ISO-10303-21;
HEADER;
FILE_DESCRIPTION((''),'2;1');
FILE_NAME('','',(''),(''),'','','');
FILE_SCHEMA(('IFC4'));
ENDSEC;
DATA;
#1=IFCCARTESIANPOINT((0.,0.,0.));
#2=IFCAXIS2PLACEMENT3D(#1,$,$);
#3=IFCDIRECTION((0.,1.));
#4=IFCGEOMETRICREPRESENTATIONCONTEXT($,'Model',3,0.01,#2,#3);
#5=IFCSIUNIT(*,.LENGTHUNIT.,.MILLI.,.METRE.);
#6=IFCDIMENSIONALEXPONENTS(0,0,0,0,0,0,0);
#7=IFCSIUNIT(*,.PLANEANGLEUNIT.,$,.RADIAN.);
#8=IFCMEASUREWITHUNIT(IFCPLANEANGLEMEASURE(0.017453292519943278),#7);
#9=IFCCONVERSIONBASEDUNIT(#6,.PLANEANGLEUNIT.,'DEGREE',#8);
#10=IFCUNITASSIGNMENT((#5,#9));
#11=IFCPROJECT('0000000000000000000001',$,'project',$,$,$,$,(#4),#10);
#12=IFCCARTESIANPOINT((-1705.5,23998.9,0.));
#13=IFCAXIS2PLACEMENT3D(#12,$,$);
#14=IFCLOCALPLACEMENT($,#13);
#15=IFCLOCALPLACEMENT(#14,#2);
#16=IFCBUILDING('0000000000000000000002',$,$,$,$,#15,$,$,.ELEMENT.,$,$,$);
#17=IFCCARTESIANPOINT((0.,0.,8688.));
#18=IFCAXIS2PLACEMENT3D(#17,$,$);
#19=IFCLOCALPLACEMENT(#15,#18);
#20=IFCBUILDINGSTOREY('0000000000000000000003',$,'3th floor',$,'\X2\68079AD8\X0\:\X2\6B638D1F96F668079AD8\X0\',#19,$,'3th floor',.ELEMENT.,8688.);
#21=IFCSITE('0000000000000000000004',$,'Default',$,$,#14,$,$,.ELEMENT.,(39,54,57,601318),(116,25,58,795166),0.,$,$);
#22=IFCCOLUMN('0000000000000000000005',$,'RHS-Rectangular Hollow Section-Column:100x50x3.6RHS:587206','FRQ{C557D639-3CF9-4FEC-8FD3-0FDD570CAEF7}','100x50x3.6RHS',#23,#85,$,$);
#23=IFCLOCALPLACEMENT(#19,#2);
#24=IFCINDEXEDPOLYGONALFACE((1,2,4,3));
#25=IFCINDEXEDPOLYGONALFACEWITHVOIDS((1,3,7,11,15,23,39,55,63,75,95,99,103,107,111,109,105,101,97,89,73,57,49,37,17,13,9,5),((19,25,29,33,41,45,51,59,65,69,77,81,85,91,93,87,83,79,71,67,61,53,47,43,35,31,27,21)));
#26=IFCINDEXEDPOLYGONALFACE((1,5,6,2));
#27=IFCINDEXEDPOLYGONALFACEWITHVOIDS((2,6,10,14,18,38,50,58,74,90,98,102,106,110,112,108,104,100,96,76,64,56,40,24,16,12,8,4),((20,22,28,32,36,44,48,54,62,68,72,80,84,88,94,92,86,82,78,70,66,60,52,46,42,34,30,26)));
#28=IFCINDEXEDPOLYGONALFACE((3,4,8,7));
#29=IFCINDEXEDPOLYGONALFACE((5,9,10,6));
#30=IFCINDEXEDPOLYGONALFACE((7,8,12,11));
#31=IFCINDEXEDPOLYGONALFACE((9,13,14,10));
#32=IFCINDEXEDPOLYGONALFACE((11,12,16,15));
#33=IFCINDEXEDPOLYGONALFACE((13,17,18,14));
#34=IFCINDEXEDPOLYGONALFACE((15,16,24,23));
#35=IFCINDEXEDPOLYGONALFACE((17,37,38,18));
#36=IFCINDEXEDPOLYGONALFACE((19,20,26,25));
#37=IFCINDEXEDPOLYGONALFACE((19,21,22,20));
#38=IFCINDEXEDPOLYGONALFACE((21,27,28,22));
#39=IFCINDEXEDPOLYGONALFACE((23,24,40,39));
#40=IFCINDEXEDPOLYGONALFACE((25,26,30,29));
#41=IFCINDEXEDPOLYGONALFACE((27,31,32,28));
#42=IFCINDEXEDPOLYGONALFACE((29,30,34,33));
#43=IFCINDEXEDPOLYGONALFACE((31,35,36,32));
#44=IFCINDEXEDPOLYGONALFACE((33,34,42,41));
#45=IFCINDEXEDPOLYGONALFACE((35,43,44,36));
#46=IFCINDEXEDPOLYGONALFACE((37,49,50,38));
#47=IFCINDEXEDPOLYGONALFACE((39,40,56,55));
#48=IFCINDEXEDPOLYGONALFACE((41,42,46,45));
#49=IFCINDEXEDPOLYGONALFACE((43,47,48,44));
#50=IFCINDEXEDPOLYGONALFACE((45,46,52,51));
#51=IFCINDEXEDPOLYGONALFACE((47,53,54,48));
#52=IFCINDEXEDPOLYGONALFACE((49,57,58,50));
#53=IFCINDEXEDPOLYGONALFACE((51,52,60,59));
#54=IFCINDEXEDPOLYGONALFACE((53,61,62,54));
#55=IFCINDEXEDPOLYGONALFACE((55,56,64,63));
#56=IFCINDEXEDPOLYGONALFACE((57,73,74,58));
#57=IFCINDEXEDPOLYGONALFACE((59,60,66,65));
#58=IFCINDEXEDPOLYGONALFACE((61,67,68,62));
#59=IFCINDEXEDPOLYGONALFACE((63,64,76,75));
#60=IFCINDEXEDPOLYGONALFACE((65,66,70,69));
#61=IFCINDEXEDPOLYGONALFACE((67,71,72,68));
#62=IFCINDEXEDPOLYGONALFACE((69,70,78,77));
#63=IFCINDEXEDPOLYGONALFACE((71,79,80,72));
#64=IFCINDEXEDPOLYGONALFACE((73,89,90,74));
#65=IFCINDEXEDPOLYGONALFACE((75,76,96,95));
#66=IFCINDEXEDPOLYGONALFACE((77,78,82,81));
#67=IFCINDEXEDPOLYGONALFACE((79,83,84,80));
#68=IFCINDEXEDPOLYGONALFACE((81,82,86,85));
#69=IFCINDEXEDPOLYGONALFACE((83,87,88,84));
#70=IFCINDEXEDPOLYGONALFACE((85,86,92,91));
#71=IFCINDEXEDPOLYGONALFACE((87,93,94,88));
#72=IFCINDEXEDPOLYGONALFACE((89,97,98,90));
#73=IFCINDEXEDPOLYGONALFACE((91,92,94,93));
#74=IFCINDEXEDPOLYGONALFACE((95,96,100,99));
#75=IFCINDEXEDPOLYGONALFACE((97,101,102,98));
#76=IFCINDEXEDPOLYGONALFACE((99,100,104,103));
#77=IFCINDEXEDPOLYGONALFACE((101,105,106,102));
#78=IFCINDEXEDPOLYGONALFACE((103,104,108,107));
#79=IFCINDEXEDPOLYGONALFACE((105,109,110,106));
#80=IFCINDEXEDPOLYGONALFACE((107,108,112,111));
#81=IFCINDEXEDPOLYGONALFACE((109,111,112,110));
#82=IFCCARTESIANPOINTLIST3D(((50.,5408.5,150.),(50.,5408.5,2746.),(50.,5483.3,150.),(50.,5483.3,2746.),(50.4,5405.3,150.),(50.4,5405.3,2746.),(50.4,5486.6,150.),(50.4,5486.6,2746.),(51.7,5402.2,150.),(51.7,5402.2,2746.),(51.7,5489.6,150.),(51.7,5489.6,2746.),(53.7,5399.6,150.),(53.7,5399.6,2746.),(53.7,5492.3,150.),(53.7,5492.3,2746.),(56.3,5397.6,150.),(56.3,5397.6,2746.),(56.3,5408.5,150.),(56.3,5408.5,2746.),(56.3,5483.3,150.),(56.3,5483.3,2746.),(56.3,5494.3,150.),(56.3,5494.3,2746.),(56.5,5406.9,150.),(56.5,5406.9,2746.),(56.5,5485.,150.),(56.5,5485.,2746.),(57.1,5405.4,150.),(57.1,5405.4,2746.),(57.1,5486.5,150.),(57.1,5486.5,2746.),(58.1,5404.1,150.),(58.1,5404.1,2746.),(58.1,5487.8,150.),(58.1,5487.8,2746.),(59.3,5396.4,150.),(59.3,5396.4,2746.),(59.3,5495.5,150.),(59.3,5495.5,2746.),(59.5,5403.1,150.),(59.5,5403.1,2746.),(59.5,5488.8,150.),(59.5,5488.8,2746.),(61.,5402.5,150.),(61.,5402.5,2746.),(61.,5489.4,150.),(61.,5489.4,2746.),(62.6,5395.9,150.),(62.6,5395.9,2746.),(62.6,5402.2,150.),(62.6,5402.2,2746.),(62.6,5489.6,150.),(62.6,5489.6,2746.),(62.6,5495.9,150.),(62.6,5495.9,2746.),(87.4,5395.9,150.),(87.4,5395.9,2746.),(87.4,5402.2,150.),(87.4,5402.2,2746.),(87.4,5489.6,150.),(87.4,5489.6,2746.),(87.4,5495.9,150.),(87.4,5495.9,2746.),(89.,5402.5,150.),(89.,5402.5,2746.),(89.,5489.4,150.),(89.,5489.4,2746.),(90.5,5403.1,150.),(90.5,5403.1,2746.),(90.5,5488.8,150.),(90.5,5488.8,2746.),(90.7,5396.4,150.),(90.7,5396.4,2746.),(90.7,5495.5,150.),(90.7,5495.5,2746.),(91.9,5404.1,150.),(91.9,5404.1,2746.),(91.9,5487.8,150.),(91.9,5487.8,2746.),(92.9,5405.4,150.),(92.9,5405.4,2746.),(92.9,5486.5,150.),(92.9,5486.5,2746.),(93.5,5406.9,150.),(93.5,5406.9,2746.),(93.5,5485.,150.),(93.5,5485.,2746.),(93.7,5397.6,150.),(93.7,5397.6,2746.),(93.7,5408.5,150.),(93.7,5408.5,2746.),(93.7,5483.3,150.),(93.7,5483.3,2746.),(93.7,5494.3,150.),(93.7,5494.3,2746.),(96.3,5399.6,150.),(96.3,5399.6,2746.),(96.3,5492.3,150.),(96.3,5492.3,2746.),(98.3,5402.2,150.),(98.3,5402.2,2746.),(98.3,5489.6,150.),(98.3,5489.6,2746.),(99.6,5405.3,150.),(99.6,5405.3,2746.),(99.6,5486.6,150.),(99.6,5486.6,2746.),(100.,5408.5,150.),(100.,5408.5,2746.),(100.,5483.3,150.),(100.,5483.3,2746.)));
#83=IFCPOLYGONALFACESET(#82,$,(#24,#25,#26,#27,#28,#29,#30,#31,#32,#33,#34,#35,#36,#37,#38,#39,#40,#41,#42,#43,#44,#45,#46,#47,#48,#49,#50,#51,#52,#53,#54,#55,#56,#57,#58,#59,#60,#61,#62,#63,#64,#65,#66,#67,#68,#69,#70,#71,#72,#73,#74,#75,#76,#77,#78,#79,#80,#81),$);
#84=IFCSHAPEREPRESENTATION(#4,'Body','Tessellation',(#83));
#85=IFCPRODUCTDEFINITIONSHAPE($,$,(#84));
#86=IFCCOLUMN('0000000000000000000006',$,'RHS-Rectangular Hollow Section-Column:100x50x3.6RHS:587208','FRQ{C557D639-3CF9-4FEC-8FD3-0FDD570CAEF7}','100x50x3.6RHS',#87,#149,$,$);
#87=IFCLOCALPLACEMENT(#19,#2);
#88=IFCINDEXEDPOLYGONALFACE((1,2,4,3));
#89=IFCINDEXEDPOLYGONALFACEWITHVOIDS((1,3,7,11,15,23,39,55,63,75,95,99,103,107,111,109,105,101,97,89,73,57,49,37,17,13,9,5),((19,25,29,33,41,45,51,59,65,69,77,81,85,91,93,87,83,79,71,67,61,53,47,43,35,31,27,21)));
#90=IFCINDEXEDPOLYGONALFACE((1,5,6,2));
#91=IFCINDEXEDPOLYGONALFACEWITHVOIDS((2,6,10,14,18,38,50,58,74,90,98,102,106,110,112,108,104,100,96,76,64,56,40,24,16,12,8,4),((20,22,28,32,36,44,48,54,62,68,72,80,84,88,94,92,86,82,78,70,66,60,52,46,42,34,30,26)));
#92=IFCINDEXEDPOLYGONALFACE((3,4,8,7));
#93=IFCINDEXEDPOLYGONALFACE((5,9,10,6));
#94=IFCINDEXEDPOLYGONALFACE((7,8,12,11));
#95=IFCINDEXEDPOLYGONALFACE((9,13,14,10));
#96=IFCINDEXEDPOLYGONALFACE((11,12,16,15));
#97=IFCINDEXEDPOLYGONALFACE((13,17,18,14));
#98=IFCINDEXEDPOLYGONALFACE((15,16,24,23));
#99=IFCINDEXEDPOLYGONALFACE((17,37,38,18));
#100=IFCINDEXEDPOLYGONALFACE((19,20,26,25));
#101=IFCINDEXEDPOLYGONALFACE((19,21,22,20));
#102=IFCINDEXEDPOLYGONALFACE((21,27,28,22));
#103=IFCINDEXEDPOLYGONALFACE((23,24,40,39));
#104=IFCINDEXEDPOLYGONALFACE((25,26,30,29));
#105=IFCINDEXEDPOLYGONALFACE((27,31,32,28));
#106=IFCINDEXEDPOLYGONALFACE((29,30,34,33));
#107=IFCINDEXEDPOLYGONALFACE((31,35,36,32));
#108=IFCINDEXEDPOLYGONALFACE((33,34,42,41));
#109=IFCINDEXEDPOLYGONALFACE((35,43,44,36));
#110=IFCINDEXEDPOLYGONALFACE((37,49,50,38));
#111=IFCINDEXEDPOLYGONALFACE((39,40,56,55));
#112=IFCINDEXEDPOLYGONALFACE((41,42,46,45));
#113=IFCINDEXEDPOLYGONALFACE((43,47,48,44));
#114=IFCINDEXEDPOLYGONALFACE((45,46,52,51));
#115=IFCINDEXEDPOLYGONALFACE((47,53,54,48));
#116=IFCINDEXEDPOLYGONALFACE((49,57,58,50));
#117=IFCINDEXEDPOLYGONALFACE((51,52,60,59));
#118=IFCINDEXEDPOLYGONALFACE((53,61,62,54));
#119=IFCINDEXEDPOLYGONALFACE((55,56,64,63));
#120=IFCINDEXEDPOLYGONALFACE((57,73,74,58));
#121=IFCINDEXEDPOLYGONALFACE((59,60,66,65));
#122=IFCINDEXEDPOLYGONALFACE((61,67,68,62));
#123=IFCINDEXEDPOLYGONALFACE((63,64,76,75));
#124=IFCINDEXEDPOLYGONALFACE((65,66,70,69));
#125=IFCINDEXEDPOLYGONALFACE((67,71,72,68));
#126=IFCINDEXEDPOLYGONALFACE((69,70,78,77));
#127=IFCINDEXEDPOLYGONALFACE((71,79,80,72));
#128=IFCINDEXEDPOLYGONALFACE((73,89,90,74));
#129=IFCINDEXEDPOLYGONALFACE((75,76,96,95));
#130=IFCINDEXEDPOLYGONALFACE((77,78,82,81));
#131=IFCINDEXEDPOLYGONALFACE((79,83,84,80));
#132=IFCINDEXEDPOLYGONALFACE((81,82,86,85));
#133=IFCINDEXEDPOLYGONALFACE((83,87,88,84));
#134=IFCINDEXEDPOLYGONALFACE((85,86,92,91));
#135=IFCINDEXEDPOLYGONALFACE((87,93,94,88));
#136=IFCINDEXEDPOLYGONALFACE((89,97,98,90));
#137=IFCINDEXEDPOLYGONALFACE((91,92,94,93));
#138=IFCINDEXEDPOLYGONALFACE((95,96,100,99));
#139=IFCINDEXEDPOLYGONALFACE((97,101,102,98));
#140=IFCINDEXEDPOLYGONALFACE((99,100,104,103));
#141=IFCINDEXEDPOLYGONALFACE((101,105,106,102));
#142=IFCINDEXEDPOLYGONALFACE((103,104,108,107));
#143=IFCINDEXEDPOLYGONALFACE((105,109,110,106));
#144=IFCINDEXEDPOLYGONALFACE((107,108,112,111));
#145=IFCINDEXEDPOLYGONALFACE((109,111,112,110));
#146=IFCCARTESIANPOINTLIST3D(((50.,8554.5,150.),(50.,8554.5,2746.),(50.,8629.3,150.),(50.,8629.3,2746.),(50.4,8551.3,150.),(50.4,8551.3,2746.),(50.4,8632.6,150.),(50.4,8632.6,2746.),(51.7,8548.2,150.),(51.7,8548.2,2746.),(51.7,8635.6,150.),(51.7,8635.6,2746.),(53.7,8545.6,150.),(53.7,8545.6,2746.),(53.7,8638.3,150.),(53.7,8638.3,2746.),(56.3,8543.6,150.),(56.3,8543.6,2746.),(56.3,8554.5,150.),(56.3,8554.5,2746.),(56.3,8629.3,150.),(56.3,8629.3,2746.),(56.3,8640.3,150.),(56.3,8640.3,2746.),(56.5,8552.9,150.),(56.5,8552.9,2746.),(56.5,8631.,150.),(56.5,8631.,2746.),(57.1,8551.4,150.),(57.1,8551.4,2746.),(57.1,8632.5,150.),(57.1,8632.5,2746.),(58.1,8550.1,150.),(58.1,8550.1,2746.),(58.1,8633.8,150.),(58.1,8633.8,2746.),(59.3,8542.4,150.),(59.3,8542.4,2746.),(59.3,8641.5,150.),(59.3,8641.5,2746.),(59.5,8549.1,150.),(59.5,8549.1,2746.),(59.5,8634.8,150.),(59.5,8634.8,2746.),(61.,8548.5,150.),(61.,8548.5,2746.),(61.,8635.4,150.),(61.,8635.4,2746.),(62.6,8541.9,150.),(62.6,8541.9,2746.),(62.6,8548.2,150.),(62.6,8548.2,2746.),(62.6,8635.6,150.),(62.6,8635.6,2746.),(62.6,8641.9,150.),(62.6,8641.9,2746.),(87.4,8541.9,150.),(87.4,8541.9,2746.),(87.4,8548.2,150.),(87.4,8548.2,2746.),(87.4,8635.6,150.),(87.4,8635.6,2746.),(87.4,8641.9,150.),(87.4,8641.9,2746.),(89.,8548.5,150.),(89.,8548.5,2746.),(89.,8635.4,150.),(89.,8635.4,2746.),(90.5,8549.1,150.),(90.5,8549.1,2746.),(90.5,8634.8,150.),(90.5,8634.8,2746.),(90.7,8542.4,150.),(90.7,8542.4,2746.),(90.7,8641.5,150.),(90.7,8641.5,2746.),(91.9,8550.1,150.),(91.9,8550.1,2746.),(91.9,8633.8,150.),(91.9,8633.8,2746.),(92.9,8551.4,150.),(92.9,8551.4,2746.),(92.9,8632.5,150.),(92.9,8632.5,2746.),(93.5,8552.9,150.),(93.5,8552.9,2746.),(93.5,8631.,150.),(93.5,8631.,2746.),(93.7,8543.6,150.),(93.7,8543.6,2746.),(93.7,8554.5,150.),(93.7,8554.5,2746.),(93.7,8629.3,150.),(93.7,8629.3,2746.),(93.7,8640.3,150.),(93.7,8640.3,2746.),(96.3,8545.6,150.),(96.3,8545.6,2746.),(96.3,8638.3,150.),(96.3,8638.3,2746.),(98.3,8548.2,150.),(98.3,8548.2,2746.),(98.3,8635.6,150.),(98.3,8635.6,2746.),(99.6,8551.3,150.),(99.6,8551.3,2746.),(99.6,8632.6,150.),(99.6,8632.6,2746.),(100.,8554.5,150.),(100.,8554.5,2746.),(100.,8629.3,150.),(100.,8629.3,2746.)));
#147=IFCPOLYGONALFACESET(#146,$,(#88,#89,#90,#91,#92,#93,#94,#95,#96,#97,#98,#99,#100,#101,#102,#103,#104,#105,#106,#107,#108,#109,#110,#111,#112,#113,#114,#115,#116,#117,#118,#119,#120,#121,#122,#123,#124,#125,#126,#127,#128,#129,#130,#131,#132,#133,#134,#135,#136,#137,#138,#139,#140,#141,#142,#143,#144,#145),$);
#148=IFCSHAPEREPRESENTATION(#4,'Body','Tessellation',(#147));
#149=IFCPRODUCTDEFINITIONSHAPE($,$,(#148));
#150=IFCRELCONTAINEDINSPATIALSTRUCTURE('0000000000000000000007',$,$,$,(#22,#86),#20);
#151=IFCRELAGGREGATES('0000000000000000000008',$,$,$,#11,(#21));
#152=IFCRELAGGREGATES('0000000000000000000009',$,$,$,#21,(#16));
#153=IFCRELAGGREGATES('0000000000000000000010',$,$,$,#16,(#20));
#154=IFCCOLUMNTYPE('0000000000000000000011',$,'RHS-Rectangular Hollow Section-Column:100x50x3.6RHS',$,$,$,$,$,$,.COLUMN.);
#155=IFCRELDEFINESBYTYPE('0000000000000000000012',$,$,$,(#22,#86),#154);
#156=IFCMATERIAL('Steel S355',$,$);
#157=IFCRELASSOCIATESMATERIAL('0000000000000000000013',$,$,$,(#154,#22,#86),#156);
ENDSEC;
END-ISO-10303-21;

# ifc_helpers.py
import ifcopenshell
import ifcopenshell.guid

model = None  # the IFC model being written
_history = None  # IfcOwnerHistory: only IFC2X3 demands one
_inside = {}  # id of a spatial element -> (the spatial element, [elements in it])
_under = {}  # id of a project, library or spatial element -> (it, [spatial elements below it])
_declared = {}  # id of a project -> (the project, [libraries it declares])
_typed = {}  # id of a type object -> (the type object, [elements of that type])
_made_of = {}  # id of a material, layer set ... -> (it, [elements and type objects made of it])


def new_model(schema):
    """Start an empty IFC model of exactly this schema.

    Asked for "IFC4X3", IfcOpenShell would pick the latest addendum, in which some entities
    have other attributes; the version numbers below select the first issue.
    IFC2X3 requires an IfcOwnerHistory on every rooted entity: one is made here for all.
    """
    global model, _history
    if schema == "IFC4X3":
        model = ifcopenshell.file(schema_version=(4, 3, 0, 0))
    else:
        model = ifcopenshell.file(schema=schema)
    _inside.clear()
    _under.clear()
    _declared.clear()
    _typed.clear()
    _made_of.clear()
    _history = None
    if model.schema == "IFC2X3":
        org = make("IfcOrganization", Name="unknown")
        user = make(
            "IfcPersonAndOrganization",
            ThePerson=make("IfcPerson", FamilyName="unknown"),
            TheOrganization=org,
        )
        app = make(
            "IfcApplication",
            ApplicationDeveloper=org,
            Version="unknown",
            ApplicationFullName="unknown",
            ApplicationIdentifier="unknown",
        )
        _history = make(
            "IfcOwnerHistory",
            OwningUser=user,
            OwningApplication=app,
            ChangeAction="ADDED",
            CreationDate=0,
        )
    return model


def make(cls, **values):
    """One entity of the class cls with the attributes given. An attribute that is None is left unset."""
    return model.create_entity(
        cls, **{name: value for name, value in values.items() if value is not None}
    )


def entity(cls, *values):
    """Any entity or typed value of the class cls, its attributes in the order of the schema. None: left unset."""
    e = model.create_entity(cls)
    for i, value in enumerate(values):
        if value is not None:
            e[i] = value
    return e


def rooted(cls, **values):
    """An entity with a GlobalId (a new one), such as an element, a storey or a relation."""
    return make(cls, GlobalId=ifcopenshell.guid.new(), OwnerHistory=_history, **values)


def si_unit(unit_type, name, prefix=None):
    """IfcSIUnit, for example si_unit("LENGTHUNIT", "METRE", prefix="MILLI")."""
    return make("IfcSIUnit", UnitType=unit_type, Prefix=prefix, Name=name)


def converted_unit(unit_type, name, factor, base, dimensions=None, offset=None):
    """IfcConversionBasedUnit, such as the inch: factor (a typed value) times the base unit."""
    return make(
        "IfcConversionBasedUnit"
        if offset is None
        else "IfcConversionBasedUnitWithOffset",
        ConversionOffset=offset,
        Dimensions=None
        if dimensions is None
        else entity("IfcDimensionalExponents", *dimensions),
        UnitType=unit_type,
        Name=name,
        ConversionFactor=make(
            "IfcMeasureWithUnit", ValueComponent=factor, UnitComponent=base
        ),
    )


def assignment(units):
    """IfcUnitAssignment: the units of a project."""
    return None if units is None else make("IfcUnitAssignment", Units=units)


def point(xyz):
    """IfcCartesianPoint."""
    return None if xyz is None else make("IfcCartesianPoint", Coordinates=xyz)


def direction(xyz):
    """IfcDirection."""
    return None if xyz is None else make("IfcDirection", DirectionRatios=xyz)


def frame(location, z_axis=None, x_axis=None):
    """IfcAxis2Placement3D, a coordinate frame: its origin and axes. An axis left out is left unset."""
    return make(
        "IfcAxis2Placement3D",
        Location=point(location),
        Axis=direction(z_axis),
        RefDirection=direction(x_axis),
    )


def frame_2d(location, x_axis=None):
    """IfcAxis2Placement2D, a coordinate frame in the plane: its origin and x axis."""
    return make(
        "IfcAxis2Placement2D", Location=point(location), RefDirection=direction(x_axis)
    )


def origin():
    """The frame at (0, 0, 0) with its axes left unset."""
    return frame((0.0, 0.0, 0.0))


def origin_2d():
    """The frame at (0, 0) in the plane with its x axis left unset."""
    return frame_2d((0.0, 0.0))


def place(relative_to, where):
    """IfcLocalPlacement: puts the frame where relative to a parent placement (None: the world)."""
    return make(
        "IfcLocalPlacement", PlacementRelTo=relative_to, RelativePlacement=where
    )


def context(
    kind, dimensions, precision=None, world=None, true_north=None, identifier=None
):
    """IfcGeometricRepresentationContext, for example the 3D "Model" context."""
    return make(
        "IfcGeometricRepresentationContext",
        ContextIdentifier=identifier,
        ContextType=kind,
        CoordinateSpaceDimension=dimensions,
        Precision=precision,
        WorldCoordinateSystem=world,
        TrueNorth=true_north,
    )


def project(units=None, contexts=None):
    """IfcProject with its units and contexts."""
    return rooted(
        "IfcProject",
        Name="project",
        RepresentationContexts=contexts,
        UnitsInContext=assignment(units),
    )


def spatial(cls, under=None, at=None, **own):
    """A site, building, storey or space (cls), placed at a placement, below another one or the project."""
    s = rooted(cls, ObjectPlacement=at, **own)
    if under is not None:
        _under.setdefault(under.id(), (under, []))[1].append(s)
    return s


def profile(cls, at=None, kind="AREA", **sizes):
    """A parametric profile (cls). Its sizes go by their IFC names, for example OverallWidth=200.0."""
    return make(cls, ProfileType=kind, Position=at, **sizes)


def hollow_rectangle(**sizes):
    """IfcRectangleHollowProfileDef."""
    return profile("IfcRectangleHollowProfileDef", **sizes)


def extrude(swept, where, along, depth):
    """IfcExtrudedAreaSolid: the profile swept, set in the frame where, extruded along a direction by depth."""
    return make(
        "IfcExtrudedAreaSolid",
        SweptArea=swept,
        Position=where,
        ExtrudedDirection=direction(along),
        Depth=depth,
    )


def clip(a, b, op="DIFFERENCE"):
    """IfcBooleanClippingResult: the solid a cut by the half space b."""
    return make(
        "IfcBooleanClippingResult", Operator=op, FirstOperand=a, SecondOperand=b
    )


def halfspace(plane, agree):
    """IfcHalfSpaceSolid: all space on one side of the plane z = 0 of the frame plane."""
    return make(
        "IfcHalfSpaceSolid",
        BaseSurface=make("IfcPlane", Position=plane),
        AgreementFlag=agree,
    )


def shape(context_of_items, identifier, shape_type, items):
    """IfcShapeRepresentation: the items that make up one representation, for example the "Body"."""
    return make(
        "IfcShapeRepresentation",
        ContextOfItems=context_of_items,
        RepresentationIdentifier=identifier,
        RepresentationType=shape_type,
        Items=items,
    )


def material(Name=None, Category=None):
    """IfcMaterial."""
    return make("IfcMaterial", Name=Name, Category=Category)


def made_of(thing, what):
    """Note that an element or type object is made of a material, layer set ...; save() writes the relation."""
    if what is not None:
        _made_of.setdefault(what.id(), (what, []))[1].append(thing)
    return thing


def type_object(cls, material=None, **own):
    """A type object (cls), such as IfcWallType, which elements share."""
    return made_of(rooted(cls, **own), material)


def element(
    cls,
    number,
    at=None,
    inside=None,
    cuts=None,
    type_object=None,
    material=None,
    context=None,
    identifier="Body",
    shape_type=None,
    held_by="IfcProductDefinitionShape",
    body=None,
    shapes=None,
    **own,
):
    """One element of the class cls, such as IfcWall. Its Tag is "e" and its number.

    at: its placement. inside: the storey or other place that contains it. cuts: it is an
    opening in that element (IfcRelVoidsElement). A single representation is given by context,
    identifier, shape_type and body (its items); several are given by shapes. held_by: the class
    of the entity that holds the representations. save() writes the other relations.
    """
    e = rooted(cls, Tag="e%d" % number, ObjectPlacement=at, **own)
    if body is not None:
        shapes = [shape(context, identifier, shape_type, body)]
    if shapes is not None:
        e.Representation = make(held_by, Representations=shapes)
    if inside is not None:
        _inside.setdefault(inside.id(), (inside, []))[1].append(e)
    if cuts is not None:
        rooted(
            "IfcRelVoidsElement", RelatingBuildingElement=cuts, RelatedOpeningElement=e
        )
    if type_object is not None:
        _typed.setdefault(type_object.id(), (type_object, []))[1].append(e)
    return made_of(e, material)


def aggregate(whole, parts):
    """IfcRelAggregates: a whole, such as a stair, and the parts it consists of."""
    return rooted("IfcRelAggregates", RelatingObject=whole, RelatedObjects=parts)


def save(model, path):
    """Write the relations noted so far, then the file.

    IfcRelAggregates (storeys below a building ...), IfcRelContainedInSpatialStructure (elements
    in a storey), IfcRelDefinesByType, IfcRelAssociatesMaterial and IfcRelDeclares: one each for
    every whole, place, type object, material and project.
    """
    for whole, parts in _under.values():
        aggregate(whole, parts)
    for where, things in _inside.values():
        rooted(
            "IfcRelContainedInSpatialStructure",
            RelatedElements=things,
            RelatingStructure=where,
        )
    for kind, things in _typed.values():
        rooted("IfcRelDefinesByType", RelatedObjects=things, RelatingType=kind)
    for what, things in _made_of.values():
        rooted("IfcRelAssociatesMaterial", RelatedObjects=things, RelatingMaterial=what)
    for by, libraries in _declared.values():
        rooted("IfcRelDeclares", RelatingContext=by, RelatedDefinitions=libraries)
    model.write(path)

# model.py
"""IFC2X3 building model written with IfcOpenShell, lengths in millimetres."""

from ifc_helpers import new_model, entity, si_unit, converted_unit, direction, frame, origin, origin_2d, place, context, project, spatial, hollow_rectangle, extrude, clip, halfspace, material, type_object, element, save


model = new_model("IFC2X3")

# Units and contexts
model_context = context("Model", 3, precision=0.01, world=origin(), true_north=direction((0.0, 1.0)))
ifc_project = project(units=[si_unit("LENGTHUNIT", "METRE", prefix="MILLI"), converted_unit("PLANEANGLEUNIT", "DEGREE", entity("IfcPlaneAngleMeasure", 0.017453292519943278), si_unit("PLANEANGLEUNIT", "RADIAN"), dimensions=[0, 0, 0, 0, 0, 0, 0])], contexts=[model_context])

# Site, building, storey
site_placement = place(None, frame((-1705.5, 23998.9, 0.0)))
site = spatial("IfcSite", under=ifc_project, at=site_placement, Name="Default", CompositionType="ELEMENT", RefLatitude=(39, 54, 57, 601318), RefLongitude=(116, 25, 58, 795166), RefElevation=0.0)
building_placement = place(site_placement, origin())
building = spatial("IfcBuilding", under=site, at=building_placement, CompositionType="ELEMENT")
storey_placement = place(building_placement, frame((0.0, 0.0, 8688.0)))
storey = spatial("IfcBuildingStorey", under=building, at=storey_placement, Name="3th floor", ObjectType="标高:正负零标高", LongName="3th floor", CompositionType="ELEMENT", Elevation=8688.0)

# Columns
ifc_material_1 = material(Name="Steel S355")
column_type_1 = type_object("IfcColumnType", Name="RHS-Rectangular Hollow Section-Column:100x50x3.6RHS", PredefinedType="COLUMN", material=ifc_material_1)
column_1_placement = place(storey_placement, frame((75.0, 5445.9, 2746.0), z_axis=(0.0, 0.0, 1.0), x_axis=(-1.0, 0.0, 0.0)))
element("IfcColumn", 1, at=column_1_placement, inside=storey, type_object=column_type_1, material=ifc_material_1, Name="RHS-Rectangular Hollow Section-Column:100x50x3.6RHS:587206", Description="FRQ{C557D639-3CF9-4FEC-8FD3-0FDD570CAEF7}", ObjectType="100x50x3.6RHS", context=model_context, shape_type="Clipping", body=[
    clip(extrude(hollow_rectangle(XDim=50.0, YDim=100.0, WallThickness=6.3, InnerFilletRadius=6.3, OuterFilletRadius=12.6, at=origin_2d()), origin(), (0.0, 0.0, -1.0), 2651.9), halfspace(frame((75.0, 5445.9, -2596.0), z_axis=(0.0, 0.0, 1.0), x_axis=(-1.0, 0.0, 0.0)), True)),
])
column_2_placement = place(storey_placement, frame((75.0, 8591.9, 2746.0), z_axis=(0.0, 0.0, 1.0), x_axis=(-1.0, 0.0, 0.0)))
element("IfcColumn", 2, at=column_2_placement, inside=storey, type_object=column_type_1, material=ifc_material_1, Name="RHS-Rectangular Hollow Section-Column:100x50x3.6RHS:587208", Description="FRQ{C557D639-3CF9-4FEC-8FD3-0FDD570CAEF7}", ObjectType="100x50x3.6RHS", context=model_context, shape_type="Clipping", body=[
    clip(extrude(hollow_rectangle(XDim=50.0, YDim=100.0, WallThickness=6.3, InnerFilletRadius=6.3, OuterFilletRadius=12.6, at=origin_2d()), origin(), (0.0, 0.0, -1.0), 2651.9), halfspace(frame((75.0, 8591.9, -2596.0), z_axis=(0.0, 0.0, 1.0), x_axis=(-1.0, 0.0, 0.0)), True)),
])

save(model, "model.ifc")
